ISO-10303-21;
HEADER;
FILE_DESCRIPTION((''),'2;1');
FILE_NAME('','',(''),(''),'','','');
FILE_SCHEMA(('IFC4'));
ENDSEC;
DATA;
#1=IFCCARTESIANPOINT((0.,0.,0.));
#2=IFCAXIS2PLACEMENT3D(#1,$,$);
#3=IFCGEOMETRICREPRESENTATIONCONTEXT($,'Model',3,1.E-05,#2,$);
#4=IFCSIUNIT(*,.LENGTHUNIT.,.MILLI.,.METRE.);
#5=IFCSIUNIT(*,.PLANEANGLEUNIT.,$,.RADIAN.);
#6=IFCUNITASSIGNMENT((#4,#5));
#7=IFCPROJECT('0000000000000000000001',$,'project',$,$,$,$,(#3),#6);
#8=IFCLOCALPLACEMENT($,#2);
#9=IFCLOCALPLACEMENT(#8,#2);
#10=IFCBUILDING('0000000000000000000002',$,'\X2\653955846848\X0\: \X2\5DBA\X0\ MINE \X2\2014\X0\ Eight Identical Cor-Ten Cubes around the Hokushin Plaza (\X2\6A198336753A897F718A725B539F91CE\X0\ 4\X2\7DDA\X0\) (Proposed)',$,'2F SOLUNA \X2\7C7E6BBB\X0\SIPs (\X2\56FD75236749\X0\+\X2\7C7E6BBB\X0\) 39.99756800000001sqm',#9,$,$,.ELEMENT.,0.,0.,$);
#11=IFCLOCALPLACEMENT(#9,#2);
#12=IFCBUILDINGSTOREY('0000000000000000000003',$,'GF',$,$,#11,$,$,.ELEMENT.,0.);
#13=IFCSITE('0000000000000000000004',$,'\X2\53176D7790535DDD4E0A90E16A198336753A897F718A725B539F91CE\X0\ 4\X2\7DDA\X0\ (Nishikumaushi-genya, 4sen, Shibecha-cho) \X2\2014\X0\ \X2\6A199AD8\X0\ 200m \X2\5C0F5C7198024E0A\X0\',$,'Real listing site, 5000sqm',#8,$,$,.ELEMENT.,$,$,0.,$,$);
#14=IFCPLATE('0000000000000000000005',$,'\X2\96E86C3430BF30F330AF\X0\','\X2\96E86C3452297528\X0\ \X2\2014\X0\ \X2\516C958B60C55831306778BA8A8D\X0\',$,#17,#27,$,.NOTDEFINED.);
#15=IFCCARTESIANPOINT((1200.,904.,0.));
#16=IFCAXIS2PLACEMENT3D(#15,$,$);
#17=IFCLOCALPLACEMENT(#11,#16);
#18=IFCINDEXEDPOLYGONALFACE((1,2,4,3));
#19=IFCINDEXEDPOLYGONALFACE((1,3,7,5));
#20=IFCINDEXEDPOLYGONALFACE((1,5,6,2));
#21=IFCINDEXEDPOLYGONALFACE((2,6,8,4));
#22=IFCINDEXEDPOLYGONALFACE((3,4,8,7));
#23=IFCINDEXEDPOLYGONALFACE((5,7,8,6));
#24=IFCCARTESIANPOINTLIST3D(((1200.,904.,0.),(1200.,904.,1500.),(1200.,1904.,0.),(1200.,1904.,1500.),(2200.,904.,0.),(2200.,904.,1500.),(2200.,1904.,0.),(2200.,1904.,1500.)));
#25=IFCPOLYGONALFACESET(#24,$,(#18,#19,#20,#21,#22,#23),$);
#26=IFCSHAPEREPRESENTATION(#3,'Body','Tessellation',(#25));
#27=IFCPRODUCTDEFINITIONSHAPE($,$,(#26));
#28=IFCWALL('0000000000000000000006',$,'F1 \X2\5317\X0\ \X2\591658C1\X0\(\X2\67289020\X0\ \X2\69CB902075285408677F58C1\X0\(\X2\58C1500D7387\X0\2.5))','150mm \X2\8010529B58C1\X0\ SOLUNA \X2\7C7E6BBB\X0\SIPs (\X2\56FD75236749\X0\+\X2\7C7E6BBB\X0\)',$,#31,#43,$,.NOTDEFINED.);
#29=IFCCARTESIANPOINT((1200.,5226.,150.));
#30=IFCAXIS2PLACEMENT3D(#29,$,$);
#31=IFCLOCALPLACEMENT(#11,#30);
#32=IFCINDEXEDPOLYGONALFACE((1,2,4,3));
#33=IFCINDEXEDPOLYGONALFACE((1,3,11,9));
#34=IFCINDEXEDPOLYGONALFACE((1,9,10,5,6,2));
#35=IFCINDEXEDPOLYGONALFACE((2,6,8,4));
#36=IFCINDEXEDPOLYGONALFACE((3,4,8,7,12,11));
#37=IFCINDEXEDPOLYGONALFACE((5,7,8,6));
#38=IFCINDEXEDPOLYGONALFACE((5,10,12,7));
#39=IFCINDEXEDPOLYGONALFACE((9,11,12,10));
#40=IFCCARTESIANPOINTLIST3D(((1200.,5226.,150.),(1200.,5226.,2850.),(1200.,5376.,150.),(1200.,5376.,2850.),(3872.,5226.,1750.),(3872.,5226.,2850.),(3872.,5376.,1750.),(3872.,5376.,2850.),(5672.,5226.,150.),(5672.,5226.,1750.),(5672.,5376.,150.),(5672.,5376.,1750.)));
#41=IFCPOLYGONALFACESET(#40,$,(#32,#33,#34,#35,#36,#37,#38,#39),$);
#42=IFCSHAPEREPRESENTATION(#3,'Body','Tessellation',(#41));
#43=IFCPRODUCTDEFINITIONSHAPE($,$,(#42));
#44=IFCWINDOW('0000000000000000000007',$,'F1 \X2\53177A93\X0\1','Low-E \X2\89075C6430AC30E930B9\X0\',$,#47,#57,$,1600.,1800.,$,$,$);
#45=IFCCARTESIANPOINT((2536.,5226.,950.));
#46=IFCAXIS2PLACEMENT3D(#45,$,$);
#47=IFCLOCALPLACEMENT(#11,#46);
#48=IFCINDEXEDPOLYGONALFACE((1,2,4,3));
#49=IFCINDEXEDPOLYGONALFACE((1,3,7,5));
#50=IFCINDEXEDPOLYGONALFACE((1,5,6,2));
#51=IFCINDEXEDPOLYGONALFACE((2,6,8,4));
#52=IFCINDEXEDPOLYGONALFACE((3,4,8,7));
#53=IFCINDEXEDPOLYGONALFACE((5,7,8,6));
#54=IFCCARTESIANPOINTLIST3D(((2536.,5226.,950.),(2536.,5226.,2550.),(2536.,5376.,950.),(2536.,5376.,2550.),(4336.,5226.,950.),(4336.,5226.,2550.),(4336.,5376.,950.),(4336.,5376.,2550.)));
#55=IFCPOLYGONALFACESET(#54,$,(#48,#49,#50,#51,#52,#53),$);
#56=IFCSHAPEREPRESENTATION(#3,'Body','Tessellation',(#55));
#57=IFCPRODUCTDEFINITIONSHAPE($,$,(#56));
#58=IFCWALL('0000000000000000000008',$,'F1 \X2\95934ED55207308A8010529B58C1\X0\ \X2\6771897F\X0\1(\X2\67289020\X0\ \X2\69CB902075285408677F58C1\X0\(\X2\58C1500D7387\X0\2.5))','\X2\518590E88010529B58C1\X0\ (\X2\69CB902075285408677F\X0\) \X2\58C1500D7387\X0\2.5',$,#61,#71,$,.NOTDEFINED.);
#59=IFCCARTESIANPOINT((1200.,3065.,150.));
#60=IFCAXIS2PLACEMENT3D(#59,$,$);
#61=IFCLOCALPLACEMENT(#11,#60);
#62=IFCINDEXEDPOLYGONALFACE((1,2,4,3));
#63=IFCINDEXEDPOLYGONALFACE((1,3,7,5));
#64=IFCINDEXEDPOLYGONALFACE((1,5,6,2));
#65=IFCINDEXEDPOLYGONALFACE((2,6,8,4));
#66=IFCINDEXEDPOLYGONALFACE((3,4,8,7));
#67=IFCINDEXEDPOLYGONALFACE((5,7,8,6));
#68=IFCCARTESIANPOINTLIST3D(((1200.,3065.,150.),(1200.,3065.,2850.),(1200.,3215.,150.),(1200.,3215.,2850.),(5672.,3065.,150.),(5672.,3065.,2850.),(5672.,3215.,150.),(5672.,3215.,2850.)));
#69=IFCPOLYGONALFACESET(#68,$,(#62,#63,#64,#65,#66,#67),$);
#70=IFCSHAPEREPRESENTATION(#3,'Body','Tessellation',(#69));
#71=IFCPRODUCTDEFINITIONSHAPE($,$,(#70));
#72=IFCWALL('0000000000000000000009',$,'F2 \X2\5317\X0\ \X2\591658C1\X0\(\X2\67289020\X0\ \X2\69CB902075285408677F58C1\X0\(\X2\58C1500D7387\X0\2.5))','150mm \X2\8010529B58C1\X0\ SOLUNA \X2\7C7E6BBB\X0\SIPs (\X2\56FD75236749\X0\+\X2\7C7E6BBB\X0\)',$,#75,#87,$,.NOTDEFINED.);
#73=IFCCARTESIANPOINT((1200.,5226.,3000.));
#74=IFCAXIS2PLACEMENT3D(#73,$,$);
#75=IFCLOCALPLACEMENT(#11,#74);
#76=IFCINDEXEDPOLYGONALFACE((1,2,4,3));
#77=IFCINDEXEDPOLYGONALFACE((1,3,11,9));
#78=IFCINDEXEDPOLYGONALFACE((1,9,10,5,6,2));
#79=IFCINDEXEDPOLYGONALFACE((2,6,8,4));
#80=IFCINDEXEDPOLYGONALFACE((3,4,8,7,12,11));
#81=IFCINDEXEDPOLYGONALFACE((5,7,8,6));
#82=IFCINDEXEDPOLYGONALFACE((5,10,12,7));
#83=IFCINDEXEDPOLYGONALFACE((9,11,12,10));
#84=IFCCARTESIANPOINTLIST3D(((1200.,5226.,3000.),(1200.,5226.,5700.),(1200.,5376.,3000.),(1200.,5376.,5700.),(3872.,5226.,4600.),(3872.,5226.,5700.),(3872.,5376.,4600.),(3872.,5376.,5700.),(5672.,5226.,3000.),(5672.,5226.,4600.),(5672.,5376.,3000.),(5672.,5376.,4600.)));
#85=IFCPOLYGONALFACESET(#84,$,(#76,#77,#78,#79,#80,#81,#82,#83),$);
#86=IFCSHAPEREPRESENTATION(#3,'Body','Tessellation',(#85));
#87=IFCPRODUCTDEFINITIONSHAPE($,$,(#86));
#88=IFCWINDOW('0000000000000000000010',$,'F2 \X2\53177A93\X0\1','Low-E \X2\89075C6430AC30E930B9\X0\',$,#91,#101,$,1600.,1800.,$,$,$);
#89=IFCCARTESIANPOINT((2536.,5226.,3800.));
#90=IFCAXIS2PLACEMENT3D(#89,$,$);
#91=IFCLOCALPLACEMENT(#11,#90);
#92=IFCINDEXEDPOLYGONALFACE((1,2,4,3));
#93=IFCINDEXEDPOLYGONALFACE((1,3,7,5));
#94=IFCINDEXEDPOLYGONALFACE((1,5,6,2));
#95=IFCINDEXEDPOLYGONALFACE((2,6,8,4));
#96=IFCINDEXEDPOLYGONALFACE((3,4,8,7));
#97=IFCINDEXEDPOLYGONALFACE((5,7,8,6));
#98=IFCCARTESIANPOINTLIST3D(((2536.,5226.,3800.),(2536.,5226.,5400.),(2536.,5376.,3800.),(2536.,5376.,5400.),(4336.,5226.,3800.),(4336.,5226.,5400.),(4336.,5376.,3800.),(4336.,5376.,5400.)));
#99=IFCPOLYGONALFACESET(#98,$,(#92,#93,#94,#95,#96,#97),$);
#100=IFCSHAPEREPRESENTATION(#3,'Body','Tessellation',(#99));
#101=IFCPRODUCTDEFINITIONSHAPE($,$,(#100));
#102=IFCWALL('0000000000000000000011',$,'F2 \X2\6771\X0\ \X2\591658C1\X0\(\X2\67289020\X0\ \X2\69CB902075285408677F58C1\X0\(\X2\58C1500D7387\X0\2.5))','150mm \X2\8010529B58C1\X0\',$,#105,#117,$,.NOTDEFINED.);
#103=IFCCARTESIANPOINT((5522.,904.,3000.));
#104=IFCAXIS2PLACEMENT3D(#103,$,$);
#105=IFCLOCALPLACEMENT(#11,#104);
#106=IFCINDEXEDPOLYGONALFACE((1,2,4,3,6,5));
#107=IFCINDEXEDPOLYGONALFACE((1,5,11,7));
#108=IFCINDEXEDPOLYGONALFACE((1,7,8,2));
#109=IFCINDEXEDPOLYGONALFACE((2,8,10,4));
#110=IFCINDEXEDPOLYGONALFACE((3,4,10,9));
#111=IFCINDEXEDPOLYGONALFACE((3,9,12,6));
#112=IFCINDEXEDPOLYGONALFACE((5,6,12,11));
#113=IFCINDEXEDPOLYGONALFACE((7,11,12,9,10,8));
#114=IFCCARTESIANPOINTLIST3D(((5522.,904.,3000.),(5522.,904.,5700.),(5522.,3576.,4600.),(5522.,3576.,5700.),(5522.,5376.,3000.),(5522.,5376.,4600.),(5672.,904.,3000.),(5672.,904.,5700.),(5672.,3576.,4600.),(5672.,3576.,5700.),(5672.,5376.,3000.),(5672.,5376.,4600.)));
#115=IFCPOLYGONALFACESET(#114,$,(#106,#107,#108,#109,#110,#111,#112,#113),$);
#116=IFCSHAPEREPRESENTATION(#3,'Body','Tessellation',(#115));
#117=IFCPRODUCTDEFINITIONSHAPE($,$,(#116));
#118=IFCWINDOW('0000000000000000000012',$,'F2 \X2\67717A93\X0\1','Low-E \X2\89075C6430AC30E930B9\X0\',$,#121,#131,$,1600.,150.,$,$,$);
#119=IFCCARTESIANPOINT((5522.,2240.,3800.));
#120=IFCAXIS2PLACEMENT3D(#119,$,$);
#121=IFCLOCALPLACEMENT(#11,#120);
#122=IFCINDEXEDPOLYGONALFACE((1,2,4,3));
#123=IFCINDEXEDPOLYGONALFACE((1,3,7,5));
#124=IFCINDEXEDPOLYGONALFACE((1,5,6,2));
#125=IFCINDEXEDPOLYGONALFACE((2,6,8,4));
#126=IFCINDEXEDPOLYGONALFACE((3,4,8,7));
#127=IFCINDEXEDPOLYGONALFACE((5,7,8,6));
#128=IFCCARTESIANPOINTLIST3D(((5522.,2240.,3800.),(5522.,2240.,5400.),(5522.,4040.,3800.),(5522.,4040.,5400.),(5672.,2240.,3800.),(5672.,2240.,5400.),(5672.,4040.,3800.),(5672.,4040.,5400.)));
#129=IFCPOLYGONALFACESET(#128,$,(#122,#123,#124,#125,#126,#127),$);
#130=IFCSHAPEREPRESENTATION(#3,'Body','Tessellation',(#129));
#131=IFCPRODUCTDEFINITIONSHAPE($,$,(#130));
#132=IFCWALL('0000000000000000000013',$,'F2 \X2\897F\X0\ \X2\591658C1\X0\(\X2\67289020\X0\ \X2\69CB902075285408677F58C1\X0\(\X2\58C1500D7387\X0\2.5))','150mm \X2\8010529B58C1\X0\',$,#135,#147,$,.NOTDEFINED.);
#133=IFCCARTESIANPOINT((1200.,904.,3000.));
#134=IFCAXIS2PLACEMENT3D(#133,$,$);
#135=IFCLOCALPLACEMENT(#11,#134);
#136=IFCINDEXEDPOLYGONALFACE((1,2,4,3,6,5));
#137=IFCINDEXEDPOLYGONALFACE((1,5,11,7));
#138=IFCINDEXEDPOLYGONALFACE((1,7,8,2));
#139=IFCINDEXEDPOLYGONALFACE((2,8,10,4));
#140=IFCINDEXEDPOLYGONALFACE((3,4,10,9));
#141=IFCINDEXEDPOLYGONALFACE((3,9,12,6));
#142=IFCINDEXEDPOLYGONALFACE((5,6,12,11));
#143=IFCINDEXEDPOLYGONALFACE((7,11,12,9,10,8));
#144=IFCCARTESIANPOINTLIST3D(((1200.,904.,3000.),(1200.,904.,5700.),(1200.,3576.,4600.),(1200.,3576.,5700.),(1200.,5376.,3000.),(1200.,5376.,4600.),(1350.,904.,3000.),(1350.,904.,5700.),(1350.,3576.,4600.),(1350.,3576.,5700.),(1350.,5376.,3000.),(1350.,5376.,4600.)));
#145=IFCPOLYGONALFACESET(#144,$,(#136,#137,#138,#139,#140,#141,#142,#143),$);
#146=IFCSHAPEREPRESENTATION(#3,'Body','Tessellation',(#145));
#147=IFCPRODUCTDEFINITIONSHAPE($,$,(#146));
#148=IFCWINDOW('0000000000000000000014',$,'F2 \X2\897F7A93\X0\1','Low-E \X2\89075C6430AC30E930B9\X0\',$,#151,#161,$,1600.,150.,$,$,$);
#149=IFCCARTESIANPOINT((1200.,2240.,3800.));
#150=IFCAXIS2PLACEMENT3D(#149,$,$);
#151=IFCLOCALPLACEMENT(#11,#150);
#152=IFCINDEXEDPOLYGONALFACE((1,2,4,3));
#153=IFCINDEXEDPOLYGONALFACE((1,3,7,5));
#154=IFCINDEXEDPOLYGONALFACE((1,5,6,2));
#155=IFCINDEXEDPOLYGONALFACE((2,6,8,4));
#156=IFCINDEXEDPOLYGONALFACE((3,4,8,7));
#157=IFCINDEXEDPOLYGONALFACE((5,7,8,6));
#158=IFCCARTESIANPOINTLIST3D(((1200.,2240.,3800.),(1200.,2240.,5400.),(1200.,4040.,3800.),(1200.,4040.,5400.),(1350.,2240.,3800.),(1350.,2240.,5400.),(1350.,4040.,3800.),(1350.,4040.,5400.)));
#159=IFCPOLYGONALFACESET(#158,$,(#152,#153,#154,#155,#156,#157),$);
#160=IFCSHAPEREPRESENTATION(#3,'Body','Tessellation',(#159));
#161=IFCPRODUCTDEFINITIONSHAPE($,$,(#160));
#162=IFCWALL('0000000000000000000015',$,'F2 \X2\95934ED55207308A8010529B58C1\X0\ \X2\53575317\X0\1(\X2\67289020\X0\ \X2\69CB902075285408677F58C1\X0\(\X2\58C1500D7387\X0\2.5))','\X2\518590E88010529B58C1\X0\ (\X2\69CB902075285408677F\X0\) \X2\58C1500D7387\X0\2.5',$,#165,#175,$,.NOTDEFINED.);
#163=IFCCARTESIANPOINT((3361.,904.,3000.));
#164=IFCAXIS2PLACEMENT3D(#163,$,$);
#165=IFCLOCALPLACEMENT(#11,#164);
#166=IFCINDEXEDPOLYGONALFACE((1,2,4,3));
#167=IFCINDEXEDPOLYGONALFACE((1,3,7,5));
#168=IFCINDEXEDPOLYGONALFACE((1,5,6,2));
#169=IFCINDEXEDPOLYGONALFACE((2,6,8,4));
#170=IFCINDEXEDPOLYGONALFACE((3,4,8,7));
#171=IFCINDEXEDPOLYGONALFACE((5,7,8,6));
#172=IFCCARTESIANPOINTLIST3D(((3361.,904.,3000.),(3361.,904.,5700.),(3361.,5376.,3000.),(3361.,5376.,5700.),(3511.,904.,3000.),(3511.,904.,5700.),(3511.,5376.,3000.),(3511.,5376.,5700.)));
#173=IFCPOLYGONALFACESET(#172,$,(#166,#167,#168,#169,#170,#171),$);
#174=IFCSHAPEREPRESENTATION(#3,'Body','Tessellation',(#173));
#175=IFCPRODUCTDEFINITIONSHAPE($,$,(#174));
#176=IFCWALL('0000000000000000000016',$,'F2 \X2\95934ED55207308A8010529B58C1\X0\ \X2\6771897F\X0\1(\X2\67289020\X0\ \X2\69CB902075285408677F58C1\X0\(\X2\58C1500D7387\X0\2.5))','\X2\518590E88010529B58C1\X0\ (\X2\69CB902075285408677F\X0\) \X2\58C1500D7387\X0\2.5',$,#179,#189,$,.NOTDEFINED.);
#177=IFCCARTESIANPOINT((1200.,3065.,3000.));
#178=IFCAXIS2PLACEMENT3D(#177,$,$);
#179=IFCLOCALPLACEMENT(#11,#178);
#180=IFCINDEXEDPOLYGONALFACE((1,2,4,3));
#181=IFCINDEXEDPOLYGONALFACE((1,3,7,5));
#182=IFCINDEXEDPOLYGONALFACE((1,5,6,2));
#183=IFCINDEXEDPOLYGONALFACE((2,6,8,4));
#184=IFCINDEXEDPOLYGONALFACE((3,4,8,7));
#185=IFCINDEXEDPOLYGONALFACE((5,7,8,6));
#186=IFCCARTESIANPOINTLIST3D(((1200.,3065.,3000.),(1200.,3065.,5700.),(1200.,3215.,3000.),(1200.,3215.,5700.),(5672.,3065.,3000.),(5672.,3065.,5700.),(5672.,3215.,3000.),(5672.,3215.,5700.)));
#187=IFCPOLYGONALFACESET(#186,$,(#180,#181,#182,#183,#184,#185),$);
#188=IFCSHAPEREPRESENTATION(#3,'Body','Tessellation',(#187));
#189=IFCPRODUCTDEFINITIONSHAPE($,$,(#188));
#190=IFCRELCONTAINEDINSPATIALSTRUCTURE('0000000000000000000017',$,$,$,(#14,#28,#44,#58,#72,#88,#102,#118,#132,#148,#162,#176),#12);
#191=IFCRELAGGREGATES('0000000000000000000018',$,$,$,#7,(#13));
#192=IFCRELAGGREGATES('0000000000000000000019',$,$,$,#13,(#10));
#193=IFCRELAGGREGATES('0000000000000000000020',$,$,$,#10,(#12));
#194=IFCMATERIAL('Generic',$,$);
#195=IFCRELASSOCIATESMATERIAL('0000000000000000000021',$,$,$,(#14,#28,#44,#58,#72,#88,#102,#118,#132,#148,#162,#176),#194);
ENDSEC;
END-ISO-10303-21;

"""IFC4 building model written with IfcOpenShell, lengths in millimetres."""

from ifc_helpers import new_model, si_unit, frame, frame_2d, origin, place, context, project, spatial, rectangle, extrude, material, element, fill, save


model = new_model("IFC4")

# Units and contexts
model_context = context("Model", 3, precision=1e-05, world=origin())
ifc_project = project(units=[si_unit("LENGTHUNIT", "METRE", prefix="MILLI"), si_unit("PLANEANGLEUNIT", "RADIAN")], contexts=[model_context])

# Site, building, storey
site_placement = place(None, origin())
site = spatial("IfcSite", under=ifc_project, at=site_placement, Name="北海道川上郡標茶町西熊牛原野 4線 (Nishikumaushi-genya, 4sen, Shibecha-cho) — 標高 200m 小山頂上", ObjectType="Real listing site, 5000sqm", CompositionType="ELEMENT", RefElevation=0.0)
building_placement = place(site_placement, origin())
building = spatial("IfcBuilding", under=site, at=building_placement, Name="改善案: 嶺 MINE — Eight Identical Cor-Ten Cubes around the Hokushin Plaza (標茶町西熊牛原野 4線) (Proposed)", ObjectType="2F SOLUNA 籾殻SIPs (国産杉+籾殻) 39.99756800000001sqm", CompositionType="ELEMENT", ElevationOfRefHeight=0.0, ElevationOfTerrain=0.0)
storey_placement = place(building_placement, origin())
storey = spatial("IfcBuildingStorey", under=building, at=storey_placement, Name="GF", CompositionType="ELEMENT", Elevation=0.0)

# Plate
ifc_material_1 = material(Name="Generic")
plate_placement = place(storey_placement, frame((1200.0, 904.0, 0.0)))
element("IfcPlate", 1, at=plate_placement, inside=storey, material=ifc_material_1, Name="雨水タンク", Description="雨水利用 — 公開情報で確認", PredefinedType="NOTDEFINED", context=model_context, shape_type="SweptSolid", body=[
    extrude(rectangle(XDim=1000.0, YDim=1000.0, at=frame_2d((500.0, 500.0))), frame((1200.0, 904.0, 0.0)), (0.0, 0.0, 1.0), 1500.0),
])

# Wall, opening, window
wall_1_placement = place(storey_placement, frame((1200.0, 5226.0, 150.0)))
wall_1 = element("IfcWall", 2, at=wall_1_placement, inside=storey, material=ifc_material_1, Name="F1 北 外壁(木造 構造用合板壁(壁倍率2.5))", Description="150mm 耐力壁 SOLUNA 籾殻SIPs (国産杉+籾殻)", PredefinedType="NOTDEFINED", context=model_context, shape_type="SweptSolid", body=[
    extrude(rectangle(XDim=4472.0, YDim=150.0, at=frame_2d((2236.0, 75.0))), frame((1200.0, 5226.0, 150.0)), (0.0, 0.0, 1.0), 2700.0),
])
opening_1_placement = place(storey_placement, frame((2536.0, 5226.0, 950.0)))
opening_1 = element("IfcOpeningElement", 3, at=opening_1_placement, cuts=wall_1, PredefinedType="NOTDEFINED", context=model_context, shape_type="SweptSolid", body=[
    extrude(rectangle(XDim=1800.0, YDim=150.0, at=frame_2d((900.0, 75.0))), frame((2536.0, 5226.0, 950.0)), (0.0, 0.0, 1.0), 1600.0),
])
window_1_placement = place(storey_placement, frame((2536.0, 5226.0, 950.0)))
window_1 = element("IfcWindow", 4, at=window_1_placement, inside=storey, material=ifc_material_1, Name="F1 北窓1", Description="Low-E 複層ガラス", OverallHeight=1600.0, OverallWidth=1800.0, context=model_context, shape_type="SweptSolid", body=[
    extrude(rectangle(XDim=1800.0, YDim=150.0, at=frame_2d((900.0, 75.0))), frame((2536.0, 5226.0, 950.0)), (0.0, 0.0, 1.0), 1600.0),
])
fill(opening_1, window_1)

# Wall
wall_2_placement = place(storey_placement, frame((1200.0, 3065.0, 150.0)))
element("IfcWall", 5, at=wall_2_placement, inside=storey, material=ifc_material_1, Name="F1 間仕切り耐力壁 東西1(木造 構造用合板壁(壁倍率2.5))", Description="内部耐力壁 (構造用合板) 壁倍率2.5", PredefinedType="NOTDEFINED", context=model_context, shape_type="SweptSolid", body=[
    extrude(rectangle(XDim=4472.0, YDim=150.0, at=frame_2d((2236.0, 75.0))), frame((1200.0, 3065.0, 150.0)), (0.0, 0.0, 1.0), 2700.0),
])

# Walls, openings, windows
wall_3_placement = place(storey_placement, frame((1200.0, 5226.0, 3000.0)))
wall_3 = element("IfcWall", 6, at=wall_3_placement, inside=storey, material=ifc_material_1, Name="F2 北 外壁(木造 構造用合板壁(壁倍率2.5))", Description="150mm 耐力壁 SOLUNA 籾殻SIPs (国産杉+籾殻)", PredefinedType="NOTDEFINED", context=model_context, shape_type="SweptSolid", body=[
    extrude(rectangle(XDim=4472.0, YDim=150.0, at=frame_2d((2236.0, 75.0))), frame((1200.0, 5226.0, 3000.0)), (0.0, 0.0, 1.0), 2700.0),
])
opening_2_placement = place(storey_placement, frame((2536.0, 5226.0, 3800.0)))
opening_2 = element("IfcOpeningElement", 7, at=opening_2_placement, cuts=wall_3, PredefinedType="NOTDEFINED", context=model_context, shape_type="SweptSolid", body=[
    extrude(rectangle(XDim=1800.0, YDim=150.0, at=frame_2d((900.0, 75.0))), frame((2536.0, 5226.0, 3800.0)), (0.0, 0.0, 1.0), 1600.0),
])
window_2_placement = place(storey_placement, frame((2536.0, 5226.0, 3800.0)))
window_2 = element("IfcWindow", 8, at=window_2_placement, inside=storey, material=ifc_material_1, Name="F2 北窓1", Description="Low-E 複層ガラス", OverallHeight=1600.0, OverallWidth=1800.0, context=model_context, shape_type="SweptSolid", body=[
    extrude(rectangle(XDim=1800.0, YDim=150.0, at=frame_2d((900.0, 75.0))), frame((2536.0, 5226.0, 3800.0)), (0.0, 0.0, 1.0), 1600.0),
])
fill(opening_2, window_2)
wall_4_placement = place(storey_placement, frame((5522.0, 904.0, 3000.0)))
wall_4 = element("IfcWall", 9, at=wall_4_placement, inside=storey, material=ifc_material_1, Name="F2 東 外壁(木造 構造用合板壁(壁倍率2.5))", Description="150mm 耐力壁", PredefinedType="NOTDEFINED", context=model_context, shape_type="SweptSolid", body=[
    extrude(rectangle(XDim=150.0, YDim=4472.0, at=frame_2d((75.0, 2236.0))), frame((5522.0, 904.0, 3000.0)), (0.0, 0.0, 1.0), 2700.0),
])
opening_3_placement = place(storey_placement, frame((5522.0, 2240.0, 3800.0)))
opening_3 = element("IfcOpeningElement", 10, at=opening_3_placement, cuts=wall_4, PredefinedType="NOTDEFINED", context=model_context, shape_type="SweptSolid", body=[
    extrude(rectangle(XDim=150.0, YDim=1800.0, at=frame_2d((75.0, 900.0))), frame((5522.0, 2240.0, 3800.0)), (0.0, 0.0, 1.0), 1600.0),
])
window_3_placement = place(storey_placement, frame((5522.0, 2240.0, 3800.0)))
window_3 = element("IfcWindow", 11, at=window_3_placement, inside=storey, material=ifc_material_1, Name="F2 東窓1", Description="Low-E 複層ガラス", OverallHeight=1600.0, OverallWidth=150.0, context=model_context, shape_type="SweptSolid", body=[
    extrude(rectangle(XDim=150.0, YDim=1800.0, at=frame_2d((75.0, 900.0))), frame((5522.0, 2240.0, 3800.0)), (0.0, 0.0, 1.0), 1600.0),
])
fill(opening_3, window_3)
wall_5_placement = place(storey_placement, frame((1200.0, 904.0, 3000.0)))
wall_5 = element("IfcWall", 12, at=wall_5_placement, inside=storey, material=ifc_material_1, Name="F2 西 外壁(木造 構造用合板壁(壁倍率2.5))", Description="150mm 耐力壁", PredefinedType="NOTDEFINED", context=model_context, shape_type="SweptSolid", body=[
    extrude(rectangle(XDim=150.0, YDim=4472.0, at=frame_2d((75.0, 2236.0))), frame((1200.0, 904.0, 3000.0)), (0.0, 0.0, 1.0), 2700.0),
])
opening_4_placement = place(storey_placement, frame((1200.0, 2240.0, 3800.0)))
opening_4 = element("IfcOpeningElement", 13, at=opening_4_placement, cuts=wall_5, PredefinedType="NOTDEFINED", context=model_context, shape_type="SweptSolid", body=[
    extrude(rectangle(XDim=150.0, YDim=1800.0, at=frame_2d((75.0, 900.0))), frame((1200.0, 2240.0, 3800.0)), (0.0, 0.0, 1.0), 1600.0),
])
window_4_placement = place(storey_placement, frame((1200.0, 2240.0, 3800.0)))
window_4 = element("IfcWindow", 14, at=window_4_placement, inside=storey, material=ifc_material_1, Name="F2 西窓1", Description="Low-E 複層ガラス", OverallHeight=1600.0, OverallWidth=150.0, context=model_context, shape_type="SweptSolid", body=[
    extrude(rectangle(XDim=150.0, YDim=1800.0, at=frame_2d((75.0, 900.0))), frame((1200.0, 2240.0, 3800.0)), (0.0, 0.0, 1.0), 1600.0),
])
fill(opening_4, window_4)

# Walls
wall_6_placement = place(storey_placement, frame((3361.0, 904.0, 3000.0)))
element("IfcWall", 15, at=wall_6_placement, inside=storey, material=ifc_material_1, Name="F2 間仕切り耐力壁 南北1(木造 構造用合板壁(壁倍率2.5))", Description="内部耐力壁 (構造用合板) 壁倍率2.5", PredefinedType="NOTDEFINED", context=model_context, shape_type="SweptSolid", body=[
    extrude(rectangle(XDim=150.0, YDim=4472.0, at=frame_2d((75.0, 2236.0))), frame((3361.0, 904.0, 3000.0)), (0.0, 0.0, 1.0), 2700.0),
])
wall_7_placement = place(storey_placement, frame((1200.0, 3065.0, 3000.0)))
element("IfcWall", 16, at=wall_7_placement, inside=storey, material=ifc_material_1, Name="F2 間仕切り耐力壁 東西1(木造 構造用合板壁(壁倍率2.5))", Description="内部耐力壁 (構造用合板) 壁倍率2.5", PredefinedType="NOTDEFINED", context=model_context, shape_type="SweptSolid", body=[
    extrude(rectangle(XDim=4472.0, YDim=150.0, at=frame_2d((2236.0, 75.0))), frame((1200.0, 3065.0, 3000.0)), (0.0, 0.0, 1.0), 2700.0),
])

save(model, "model.ifc")
